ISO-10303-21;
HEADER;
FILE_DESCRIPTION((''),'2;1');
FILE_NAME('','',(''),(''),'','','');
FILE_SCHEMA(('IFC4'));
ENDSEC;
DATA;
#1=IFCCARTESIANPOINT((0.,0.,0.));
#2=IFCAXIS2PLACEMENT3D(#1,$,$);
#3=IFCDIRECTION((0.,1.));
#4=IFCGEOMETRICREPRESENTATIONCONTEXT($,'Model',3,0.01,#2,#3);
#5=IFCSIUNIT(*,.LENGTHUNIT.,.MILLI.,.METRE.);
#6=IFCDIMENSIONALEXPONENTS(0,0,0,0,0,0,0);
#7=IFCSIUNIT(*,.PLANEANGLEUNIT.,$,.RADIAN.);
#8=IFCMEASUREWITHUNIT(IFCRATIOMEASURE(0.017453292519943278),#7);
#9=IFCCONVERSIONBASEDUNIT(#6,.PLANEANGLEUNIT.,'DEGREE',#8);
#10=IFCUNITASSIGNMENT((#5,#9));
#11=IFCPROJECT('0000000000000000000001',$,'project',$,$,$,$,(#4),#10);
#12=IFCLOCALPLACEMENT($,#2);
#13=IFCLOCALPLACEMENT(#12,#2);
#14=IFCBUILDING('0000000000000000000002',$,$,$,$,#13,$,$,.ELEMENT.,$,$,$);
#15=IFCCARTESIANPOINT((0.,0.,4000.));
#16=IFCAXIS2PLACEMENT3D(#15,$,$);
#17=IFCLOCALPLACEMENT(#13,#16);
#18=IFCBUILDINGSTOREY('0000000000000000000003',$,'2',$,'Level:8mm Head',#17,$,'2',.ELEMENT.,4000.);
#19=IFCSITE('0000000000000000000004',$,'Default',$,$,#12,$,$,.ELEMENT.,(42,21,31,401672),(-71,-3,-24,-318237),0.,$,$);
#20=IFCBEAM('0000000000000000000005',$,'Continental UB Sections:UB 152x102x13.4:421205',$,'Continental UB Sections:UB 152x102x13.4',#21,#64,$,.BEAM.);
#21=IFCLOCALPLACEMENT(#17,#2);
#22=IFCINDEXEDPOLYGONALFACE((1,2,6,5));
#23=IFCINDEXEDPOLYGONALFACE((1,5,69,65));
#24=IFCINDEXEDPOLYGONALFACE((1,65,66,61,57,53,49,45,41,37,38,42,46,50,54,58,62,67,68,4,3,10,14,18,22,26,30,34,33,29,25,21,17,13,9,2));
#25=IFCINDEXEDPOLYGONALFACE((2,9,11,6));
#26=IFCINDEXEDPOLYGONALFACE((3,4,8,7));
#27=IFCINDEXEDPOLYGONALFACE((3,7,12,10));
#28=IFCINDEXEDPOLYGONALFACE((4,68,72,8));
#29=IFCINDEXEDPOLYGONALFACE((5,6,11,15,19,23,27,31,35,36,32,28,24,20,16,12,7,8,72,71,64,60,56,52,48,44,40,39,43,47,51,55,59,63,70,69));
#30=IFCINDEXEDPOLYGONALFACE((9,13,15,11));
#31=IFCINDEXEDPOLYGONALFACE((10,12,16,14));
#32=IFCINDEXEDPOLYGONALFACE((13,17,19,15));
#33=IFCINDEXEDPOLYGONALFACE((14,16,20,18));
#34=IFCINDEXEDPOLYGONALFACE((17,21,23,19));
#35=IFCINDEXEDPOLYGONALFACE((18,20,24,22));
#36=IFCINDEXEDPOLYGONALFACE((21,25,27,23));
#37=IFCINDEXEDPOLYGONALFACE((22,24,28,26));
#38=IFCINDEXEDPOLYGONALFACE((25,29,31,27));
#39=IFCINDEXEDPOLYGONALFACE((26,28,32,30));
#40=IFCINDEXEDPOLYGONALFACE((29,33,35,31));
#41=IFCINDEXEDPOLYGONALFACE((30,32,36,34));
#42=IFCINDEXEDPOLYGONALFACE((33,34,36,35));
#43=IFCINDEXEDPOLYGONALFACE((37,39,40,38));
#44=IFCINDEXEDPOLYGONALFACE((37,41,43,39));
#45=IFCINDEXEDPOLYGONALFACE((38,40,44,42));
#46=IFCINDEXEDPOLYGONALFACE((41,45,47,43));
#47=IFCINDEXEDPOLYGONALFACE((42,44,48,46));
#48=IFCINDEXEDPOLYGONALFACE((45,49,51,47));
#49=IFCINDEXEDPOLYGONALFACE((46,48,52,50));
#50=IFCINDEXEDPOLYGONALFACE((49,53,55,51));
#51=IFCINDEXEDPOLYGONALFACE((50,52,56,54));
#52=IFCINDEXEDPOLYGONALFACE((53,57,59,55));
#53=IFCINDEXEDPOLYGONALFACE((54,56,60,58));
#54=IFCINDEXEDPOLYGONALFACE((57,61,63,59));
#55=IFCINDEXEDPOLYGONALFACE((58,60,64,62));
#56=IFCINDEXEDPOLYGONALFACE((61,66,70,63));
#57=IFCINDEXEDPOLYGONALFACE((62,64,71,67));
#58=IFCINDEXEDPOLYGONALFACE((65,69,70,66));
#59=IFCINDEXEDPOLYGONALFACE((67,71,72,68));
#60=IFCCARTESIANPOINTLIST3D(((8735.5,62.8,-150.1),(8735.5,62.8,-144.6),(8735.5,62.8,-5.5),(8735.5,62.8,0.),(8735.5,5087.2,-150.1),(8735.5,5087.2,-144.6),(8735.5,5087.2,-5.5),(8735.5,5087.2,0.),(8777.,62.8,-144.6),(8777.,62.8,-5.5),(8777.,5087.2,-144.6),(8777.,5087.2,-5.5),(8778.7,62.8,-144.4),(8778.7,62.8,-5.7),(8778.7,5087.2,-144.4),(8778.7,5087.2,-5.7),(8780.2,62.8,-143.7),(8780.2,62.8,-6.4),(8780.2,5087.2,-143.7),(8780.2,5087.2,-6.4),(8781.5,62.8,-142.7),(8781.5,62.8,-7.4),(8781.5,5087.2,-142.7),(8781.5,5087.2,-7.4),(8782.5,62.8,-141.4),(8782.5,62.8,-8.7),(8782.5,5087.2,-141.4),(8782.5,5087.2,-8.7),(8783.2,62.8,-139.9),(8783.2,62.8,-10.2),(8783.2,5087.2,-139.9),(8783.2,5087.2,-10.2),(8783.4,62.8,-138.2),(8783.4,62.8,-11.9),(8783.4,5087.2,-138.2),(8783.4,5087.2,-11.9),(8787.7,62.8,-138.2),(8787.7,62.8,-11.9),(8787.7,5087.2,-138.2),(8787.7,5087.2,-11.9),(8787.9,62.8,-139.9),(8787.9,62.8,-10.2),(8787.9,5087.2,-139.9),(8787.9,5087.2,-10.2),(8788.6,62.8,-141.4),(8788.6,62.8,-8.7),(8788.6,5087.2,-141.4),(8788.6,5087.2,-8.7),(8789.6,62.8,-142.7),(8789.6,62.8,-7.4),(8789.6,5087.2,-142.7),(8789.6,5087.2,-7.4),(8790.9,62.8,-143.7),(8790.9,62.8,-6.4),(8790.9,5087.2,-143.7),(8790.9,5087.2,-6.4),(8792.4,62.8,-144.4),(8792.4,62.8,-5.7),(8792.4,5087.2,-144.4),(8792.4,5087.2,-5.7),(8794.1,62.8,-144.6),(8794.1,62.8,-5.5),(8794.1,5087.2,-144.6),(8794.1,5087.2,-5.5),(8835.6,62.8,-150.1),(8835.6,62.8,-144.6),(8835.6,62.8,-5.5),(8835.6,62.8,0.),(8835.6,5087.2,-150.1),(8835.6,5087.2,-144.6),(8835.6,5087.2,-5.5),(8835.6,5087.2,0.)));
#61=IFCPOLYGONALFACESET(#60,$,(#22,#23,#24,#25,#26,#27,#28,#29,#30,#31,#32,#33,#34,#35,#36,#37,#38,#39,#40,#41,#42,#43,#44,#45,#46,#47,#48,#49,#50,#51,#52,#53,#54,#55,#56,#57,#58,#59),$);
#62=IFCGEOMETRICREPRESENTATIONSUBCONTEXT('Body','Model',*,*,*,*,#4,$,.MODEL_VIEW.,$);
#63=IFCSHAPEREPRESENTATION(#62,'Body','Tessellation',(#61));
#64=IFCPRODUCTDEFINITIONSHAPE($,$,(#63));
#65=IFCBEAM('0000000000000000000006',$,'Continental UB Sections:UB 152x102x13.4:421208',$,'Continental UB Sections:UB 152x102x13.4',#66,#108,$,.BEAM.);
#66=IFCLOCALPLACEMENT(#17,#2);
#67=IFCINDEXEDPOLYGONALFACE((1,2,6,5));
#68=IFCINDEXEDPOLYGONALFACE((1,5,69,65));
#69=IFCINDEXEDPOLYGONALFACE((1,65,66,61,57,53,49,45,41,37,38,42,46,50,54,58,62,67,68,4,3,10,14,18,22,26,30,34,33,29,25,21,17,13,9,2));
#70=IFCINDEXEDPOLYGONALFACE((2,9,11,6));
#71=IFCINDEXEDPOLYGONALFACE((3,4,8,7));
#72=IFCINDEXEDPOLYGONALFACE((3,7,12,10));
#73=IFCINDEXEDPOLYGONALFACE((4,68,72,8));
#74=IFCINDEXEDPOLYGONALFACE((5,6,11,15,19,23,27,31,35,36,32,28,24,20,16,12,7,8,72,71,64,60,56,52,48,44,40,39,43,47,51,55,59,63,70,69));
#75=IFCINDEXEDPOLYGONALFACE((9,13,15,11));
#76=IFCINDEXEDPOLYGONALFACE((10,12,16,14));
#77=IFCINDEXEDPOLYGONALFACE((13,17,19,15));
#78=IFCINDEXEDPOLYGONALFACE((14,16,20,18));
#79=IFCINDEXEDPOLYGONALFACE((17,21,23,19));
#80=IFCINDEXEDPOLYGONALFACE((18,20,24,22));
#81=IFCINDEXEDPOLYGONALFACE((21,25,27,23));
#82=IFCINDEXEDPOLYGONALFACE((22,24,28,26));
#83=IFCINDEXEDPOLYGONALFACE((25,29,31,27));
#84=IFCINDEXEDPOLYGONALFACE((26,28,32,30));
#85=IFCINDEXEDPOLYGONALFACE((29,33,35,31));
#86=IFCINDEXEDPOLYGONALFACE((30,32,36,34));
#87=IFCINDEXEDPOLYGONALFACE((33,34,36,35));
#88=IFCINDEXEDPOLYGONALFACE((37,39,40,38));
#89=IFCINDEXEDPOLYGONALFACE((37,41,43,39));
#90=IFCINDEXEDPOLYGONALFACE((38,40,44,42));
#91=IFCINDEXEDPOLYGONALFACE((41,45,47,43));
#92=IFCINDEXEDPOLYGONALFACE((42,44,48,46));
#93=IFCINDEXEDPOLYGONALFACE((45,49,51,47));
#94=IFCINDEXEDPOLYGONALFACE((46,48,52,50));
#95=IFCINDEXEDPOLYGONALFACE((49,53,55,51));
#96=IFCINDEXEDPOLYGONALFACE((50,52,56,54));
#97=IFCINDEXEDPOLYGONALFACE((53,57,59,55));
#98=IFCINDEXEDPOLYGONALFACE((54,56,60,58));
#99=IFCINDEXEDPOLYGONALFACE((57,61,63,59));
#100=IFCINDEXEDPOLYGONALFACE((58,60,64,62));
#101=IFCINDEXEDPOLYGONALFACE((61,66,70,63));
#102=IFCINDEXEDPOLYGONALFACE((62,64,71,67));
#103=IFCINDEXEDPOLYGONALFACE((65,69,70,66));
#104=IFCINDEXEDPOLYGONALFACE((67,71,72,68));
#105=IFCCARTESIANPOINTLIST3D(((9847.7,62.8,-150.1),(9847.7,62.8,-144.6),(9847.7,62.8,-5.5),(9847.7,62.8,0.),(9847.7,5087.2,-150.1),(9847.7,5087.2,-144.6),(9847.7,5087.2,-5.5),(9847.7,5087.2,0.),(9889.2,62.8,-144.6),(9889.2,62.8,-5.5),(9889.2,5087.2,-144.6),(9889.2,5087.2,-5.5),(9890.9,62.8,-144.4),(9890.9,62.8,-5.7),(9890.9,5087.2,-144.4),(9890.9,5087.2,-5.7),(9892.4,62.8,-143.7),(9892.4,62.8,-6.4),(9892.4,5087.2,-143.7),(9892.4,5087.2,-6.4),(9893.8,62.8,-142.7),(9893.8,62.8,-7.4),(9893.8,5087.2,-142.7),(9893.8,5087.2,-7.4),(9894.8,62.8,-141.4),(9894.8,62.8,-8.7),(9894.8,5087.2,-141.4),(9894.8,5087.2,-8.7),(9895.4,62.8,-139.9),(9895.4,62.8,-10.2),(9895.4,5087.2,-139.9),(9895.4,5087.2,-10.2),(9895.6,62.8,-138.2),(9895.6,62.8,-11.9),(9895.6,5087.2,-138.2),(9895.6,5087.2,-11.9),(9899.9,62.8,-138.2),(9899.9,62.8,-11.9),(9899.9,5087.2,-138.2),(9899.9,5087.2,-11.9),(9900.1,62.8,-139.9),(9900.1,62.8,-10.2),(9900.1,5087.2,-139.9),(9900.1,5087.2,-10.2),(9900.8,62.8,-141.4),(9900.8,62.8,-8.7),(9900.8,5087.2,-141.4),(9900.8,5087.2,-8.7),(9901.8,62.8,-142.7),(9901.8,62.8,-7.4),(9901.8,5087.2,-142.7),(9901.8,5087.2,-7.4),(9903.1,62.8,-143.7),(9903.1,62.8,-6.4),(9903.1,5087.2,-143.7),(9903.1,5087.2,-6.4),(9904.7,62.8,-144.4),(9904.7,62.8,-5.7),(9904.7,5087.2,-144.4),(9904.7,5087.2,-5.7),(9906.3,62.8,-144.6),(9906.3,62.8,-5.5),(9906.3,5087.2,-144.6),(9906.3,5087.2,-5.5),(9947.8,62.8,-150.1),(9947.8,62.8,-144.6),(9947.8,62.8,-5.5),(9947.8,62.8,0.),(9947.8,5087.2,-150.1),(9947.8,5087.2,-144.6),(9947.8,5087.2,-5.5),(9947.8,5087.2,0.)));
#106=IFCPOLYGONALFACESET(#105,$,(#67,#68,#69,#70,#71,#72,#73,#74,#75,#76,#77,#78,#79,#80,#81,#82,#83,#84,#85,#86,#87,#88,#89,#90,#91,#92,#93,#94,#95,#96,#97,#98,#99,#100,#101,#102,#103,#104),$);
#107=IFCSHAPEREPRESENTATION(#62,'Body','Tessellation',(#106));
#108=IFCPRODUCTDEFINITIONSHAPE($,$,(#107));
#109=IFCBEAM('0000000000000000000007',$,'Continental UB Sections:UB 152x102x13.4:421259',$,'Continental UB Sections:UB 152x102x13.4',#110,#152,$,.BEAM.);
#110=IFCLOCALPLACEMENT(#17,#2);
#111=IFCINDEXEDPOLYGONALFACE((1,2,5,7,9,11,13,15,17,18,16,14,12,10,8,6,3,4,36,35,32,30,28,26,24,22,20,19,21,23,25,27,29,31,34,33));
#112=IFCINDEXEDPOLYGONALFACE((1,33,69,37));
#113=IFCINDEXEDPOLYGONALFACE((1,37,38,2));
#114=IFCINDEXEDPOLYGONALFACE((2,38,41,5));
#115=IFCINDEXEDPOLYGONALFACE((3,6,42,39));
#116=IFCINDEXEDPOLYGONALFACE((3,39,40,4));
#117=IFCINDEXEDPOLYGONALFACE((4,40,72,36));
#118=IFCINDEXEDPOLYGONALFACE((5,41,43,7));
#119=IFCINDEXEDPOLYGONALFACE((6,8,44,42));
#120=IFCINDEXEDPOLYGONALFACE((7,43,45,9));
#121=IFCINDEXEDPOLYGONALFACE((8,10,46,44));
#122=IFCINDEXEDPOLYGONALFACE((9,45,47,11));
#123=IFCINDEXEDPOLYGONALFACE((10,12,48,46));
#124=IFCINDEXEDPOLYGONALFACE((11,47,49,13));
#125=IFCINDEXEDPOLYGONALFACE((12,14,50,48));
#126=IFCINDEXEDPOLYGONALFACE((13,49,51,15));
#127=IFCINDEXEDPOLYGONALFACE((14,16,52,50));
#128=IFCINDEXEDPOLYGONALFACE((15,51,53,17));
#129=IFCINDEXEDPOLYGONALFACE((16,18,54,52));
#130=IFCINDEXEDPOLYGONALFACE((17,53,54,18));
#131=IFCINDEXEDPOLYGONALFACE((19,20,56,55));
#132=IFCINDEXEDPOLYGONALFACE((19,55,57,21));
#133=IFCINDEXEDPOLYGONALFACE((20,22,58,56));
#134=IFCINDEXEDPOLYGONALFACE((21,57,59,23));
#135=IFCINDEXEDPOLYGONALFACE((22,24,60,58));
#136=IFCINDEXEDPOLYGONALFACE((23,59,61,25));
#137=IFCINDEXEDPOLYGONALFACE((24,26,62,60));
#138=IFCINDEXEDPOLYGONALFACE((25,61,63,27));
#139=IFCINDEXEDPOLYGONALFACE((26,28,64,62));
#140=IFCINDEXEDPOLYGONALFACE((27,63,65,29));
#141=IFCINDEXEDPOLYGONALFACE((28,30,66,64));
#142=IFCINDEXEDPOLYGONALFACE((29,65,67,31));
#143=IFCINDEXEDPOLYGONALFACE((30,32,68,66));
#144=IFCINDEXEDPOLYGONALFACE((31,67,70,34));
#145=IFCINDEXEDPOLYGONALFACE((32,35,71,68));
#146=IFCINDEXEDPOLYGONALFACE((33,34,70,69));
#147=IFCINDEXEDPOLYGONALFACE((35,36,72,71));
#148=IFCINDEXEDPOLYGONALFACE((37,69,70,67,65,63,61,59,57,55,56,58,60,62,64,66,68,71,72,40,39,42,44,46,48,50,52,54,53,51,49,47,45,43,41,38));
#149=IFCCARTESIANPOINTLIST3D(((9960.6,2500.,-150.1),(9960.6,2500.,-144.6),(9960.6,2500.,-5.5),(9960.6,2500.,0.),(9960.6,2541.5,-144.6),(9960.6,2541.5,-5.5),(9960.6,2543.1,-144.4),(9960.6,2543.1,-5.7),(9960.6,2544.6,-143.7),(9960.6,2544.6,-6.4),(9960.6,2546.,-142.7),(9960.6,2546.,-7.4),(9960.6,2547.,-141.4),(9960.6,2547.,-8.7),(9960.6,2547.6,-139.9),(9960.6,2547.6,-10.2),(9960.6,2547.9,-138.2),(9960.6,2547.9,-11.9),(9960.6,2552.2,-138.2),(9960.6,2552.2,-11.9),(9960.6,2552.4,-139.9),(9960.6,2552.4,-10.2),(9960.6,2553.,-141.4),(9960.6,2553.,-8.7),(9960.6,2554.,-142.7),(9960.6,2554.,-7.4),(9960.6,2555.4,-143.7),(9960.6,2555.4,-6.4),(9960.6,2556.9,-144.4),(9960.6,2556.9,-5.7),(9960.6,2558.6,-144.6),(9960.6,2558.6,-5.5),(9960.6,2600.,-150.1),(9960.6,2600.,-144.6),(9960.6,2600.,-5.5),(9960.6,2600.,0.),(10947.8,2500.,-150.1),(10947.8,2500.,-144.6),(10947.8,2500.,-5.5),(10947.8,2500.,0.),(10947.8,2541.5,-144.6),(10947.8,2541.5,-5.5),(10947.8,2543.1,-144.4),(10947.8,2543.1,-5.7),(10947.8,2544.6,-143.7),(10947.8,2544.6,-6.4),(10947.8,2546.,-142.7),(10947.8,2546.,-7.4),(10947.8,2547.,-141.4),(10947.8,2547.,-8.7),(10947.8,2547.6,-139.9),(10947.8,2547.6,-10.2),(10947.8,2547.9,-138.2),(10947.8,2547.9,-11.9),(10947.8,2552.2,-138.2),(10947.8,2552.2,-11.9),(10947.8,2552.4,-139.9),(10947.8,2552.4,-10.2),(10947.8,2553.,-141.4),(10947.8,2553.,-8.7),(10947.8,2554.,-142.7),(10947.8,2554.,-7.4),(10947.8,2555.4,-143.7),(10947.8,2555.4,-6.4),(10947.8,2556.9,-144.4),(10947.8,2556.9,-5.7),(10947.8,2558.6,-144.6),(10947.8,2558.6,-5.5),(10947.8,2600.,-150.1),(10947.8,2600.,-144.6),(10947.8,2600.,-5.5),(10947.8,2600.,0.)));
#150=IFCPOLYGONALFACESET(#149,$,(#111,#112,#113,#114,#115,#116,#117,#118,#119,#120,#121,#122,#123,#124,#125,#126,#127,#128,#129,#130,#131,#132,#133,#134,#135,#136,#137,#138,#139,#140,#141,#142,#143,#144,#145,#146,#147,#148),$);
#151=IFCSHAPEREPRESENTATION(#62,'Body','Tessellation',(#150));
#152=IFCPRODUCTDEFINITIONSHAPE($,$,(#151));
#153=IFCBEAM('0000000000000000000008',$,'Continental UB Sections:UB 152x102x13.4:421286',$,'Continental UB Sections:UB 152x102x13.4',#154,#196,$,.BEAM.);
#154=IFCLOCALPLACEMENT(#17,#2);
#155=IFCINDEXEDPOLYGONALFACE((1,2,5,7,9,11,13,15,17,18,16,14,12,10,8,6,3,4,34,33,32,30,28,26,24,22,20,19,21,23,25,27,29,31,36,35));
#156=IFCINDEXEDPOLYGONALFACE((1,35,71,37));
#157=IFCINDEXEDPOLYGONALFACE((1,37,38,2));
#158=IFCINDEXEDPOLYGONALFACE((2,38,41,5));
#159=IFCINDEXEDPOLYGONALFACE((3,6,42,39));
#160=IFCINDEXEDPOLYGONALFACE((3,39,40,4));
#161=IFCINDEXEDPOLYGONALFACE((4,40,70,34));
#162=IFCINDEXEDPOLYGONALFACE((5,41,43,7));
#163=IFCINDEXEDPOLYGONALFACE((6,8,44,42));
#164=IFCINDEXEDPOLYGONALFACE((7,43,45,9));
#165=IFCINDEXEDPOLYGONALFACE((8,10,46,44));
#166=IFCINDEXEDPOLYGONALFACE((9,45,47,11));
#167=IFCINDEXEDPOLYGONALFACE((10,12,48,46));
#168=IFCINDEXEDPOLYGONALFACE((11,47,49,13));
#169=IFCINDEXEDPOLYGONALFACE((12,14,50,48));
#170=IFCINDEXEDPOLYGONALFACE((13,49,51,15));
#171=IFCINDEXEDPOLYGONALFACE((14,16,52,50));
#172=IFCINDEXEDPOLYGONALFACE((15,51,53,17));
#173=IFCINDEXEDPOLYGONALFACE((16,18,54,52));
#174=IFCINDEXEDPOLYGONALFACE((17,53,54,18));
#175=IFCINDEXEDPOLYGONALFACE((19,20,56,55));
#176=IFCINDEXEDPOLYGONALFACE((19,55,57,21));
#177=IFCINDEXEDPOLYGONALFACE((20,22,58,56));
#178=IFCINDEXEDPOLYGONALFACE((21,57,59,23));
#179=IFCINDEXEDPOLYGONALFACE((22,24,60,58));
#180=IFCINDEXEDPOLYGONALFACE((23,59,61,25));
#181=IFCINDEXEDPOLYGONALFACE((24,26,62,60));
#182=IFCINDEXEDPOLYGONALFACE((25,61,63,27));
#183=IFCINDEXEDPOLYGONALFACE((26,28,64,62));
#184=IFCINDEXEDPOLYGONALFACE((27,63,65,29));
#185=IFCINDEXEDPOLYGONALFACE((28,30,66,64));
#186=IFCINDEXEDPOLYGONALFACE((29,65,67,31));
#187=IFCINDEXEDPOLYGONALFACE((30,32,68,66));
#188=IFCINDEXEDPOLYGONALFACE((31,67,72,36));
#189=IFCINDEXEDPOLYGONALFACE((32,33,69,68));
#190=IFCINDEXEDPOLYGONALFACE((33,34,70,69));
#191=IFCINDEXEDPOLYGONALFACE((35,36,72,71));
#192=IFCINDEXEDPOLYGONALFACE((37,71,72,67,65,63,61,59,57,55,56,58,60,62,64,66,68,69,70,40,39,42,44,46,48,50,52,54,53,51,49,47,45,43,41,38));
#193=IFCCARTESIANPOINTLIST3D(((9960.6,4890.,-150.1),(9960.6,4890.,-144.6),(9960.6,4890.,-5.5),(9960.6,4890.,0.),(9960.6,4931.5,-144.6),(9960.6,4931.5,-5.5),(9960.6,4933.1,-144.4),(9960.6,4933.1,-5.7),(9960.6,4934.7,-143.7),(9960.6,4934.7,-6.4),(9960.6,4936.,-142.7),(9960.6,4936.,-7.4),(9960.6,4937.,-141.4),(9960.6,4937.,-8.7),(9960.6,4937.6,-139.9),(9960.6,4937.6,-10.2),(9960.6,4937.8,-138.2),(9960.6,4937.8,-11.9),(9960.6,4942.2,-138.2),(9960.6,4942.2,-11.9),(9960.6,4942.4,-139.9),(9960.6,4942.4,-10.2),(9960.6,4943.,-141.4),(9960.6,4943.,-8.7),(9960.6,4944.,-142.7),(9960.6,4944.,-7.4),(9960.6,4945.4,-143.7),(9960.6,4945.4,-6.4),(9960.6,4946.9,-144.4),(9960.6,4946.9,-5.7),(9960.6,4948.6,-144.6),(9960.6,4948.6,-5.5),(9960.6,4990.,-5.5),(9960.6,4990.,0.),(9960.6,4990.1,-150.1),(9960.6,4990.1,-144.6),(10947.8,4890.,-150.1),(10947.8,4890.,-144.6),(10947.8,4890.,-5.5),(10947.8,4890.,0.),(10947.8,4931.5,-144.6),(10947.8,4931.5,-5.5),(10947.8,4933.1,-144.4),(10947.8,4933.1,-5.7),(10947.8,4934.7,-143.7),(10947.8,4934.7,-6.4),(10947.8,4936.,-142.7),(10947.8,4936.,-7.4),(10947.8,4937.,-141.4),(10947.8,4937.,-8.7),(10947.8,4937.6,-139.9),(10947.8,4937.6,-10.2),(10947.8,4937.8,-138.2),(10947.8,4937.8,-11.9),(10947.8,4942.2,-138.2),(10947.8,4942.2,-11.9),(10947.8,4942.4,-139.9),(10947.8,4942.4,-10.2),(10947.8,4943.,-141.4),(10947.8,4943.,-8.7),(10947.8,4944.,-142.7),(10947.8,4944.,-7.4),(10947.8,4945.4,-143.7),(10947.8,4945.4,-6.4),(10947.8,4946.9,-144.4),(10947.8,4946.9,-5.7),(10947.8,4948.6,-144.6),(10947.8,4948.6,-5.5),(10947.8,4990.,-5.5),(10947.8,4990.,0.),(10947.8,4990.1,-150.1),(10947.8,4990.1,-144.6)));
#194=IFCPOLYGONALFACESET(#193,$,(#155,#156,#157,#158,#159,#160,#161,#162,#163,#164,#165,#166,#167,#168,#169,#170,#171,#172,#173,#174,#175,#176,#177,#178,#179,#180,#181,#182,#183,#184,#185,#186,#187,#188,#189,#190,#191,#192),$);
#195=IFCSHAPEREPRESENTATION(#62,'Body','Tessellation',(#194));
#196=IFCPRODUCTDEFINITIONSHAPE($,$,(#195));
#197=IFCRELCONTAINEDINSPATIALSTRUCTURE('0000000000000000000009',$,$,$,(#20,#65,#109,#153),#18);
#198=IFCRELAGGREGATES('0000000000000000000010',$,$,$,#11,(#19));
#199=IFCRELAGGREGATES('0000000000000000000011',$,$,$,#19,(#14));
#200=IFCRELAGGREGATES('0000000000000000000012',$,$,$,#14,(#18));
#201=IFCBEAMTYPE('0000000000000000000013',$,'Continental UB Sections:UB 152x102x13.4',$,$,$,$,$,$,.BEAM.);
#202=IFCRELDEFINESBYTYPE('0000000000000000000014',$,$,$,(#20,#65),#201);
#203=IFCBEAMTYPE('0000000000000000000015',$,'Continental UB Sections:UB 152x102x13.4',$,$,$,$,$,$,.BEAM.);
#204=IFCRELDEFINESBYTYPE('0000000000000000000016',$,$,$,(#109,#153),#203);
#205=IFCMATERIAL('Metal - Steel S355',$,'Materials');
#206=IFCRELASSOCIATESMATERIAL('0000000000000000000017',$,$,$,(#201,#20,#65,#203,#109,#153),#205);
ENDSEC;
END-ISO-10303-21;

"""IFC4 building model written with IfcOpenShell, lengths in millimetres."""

from ifc_helpers import new_model, entity, si_unit, converted_unit, direction, frame, origin, place, context, subcontext, project, spatial, line, arc, indexed_curve, outline, extrude, source, transform, mapped, material, type_object, type_shapes, element, save


model = new_model("IFC4")

# Units and contexts
model_context = context("Model", 3, precision=0.01, world=origin(), true_north=direction((0.0, 1.0)))
body_context = subcontext(model_context, "Body", "Model", "MODEL_VIEW")
ifc_project = project(units=[si_unit("LENGTHUNIT", "METRE", prefix="MILLI"), converted_unit("PLANEANGLEUNIT", "DEGREE", entity("IfcRatioMeasure", 0.017453292519943278), si_unit("PLANEANGLEUNIT", "RADIAN"), dimensions=[0, 0, 0, 0, 0, 0, 0])], contexts=[model_context])

# Site, building, storey
site_placement = place(None, origin())
site = spatial("IfcSite", under=ifc_project, at=site_placement, Name="Default", CompositionType="ELEMENT", RefLatitude=(42, 21, 31, 401672), RefLongitude=(-71, -3, -24, -318237), RefElevation=0.0)
building_placement = place(site_placement, origin())
building = spatial("IfcBuilding", under=site, at=building_placement, CompositionType="ELEMENT")
storey_placement = place(building_placement, frame((0.0, 0.0, 4000.0)))
storey = spatial("IfcBuildingStorey", under=building, at=storey_placement, Name="2", ObjectType="Level:8mm Head", LongName="2", CompositionType="ELEMENT", Elevation=4000.0)

# Beams
ifc_material = material(Name="Metal - Steel S355", Category="Materials")
beam_type_1 = type_object("IfcBeamType", Name="Continental UB Sections:UB 152x102x13.4", PredefinedType="BEAM", material=ifc_material)
shared_shape_1 = source(origin(), body_context, "Body", "SweptSolid", [
    extrude(outline(indexed_curve([(-75.0, -50.1), (-69.6, -50.1), (-69.6, -8.5), (-67.7, -4.0), (-63.2, -2.1), (63.1, -2.1), (67.7, -4.0), (69.5, -8.5), (69.5, -50.1), (75.1, -50.1), (75.1, 50.1), (69.5, 50.1), (69.5, 8.6), (67.7, 4.0), (63.1, 2.2), (-63.2, 2.2), (-67.7, 4.0), (-69.6, 8.6), (-69.6, 50.0), (-75.0, 50.0)], segments=[line(1, 2, 3), arc(3, 4, 5), line(5, 6), arc(6, 7, 8), line(8, 9, 10, 11, 12, 13), arc(13, 14, 15), line(15, 16), arc(16, 17, 18), line(18, 19, 20, 1)], self_intersect=False)), frame((-2487.2, 0.0, 0.0), z_axis=(1.0, 0.0, 0.0), x_axis=(0.0, 0.0, -1.0)), (0.0, 0.0, 1.0), 5024.4),
])
type_shapes(beam_type_1, [shared_shape_1])
for number, where, z_axis, x_axis, name in (
    (1, (8785.6, 2550.0, -75.1), (0.0, 0.0, 1.0), (0.0, 1.0, 0.0), "Continental UB Sections:UB 152x102x13.4:421205"),
    (2, (9897.8, 2550.0, -75.1), (0.0, 0.0, 1.0), (0.0, 1.0, 0.0), "Continental UB Sections:UB 152x102x13.4:421208"),
):
    element("IfcBeam", number, at=place(storey_placement, frame(where, z_axis=z_axis, x_axis=x_axis)), inside=storey, type_object=beam_type_1, material=ifc_material, Name=name, ObjectType="Continental UB Sections:UB 152x102x13.4", PredefinedType="BEAM", context=body_context, shape_type="MappedRepresentation", body=[
        mapped(shared_shape_1, transform((0.0, 0.0, 0.0), scale=1.0)),
    ])
beam_type_2 = type_object("IfcBeamType", Name="Continental UB Sections:UB 152x102x13.4", PredefinedType="BEAM", material=ifc_material)
shared_shape_2 = source(origin(), body_context, "Body", "SweptSolid", [
    extrude(outline(indexed_curve([(-75.0, -50.1), (-69.6, -50.1), (-69.6, -8.5), (-67.7, -4.0), (-63.2, -2.1), (63.1, -2.1), (67.7, -4.0), (69.5, -8.5), (69.5, -50.1), (75.1, -50.1), (75.1, 50.1), (69.5, 50.1), (69.5, 8.6), (67.7, 4.0), (63.1, 2.2), (-63.2, 2.2), (-67.7, 4.0), (-69.6, 8.6), (-69.6, 50.0), (-75.0, 50.0)], segments=[line(1, 2, 3), arc(3, 4, 5), line(5, 6), arc(6, 7, 8), line(8, 9, 10, 11, 12, 13), arc(13, 14, 15), line(15, 16), arc(16, 17, 18), line(18, 19, 20, 1)], self_intersect=False)), frame((-493.3, 0.0, 0.0), z_axis=(1.0, 0.0, 0.0), x_axis=(0.0, 0.0, -1.0)), (0.0, 0.0, 1.0), 987.2),
])
type_shapes(beam_type_2, [shared_shape_2])
for number, where, name in (
    (3, (10453.9, 2550.0, -75.1), "Continental UB Sections:UB 152x102x13.4:421259"),
    (4, (10453.9, 4940.0, -75.1), "Continental UB Sections:UB 152x102x13.4:421286"),
):
    element("IfcBeam", number, at=place(storey_placement, frame(where)), inside=storey, type_object=beam_type_2, material=ifc_material, Name=name, ObjectType="Continental UB Sections:UB 152x102x13.4", PredefinedType="BEAM", context=body_context, shape_type="MappedRepresentation", body=[
        mapped(shared_shape_2, transform((0.0, 0.0, 0.0), scale=1.0)),
    ])

save(model, "model.ifc")
